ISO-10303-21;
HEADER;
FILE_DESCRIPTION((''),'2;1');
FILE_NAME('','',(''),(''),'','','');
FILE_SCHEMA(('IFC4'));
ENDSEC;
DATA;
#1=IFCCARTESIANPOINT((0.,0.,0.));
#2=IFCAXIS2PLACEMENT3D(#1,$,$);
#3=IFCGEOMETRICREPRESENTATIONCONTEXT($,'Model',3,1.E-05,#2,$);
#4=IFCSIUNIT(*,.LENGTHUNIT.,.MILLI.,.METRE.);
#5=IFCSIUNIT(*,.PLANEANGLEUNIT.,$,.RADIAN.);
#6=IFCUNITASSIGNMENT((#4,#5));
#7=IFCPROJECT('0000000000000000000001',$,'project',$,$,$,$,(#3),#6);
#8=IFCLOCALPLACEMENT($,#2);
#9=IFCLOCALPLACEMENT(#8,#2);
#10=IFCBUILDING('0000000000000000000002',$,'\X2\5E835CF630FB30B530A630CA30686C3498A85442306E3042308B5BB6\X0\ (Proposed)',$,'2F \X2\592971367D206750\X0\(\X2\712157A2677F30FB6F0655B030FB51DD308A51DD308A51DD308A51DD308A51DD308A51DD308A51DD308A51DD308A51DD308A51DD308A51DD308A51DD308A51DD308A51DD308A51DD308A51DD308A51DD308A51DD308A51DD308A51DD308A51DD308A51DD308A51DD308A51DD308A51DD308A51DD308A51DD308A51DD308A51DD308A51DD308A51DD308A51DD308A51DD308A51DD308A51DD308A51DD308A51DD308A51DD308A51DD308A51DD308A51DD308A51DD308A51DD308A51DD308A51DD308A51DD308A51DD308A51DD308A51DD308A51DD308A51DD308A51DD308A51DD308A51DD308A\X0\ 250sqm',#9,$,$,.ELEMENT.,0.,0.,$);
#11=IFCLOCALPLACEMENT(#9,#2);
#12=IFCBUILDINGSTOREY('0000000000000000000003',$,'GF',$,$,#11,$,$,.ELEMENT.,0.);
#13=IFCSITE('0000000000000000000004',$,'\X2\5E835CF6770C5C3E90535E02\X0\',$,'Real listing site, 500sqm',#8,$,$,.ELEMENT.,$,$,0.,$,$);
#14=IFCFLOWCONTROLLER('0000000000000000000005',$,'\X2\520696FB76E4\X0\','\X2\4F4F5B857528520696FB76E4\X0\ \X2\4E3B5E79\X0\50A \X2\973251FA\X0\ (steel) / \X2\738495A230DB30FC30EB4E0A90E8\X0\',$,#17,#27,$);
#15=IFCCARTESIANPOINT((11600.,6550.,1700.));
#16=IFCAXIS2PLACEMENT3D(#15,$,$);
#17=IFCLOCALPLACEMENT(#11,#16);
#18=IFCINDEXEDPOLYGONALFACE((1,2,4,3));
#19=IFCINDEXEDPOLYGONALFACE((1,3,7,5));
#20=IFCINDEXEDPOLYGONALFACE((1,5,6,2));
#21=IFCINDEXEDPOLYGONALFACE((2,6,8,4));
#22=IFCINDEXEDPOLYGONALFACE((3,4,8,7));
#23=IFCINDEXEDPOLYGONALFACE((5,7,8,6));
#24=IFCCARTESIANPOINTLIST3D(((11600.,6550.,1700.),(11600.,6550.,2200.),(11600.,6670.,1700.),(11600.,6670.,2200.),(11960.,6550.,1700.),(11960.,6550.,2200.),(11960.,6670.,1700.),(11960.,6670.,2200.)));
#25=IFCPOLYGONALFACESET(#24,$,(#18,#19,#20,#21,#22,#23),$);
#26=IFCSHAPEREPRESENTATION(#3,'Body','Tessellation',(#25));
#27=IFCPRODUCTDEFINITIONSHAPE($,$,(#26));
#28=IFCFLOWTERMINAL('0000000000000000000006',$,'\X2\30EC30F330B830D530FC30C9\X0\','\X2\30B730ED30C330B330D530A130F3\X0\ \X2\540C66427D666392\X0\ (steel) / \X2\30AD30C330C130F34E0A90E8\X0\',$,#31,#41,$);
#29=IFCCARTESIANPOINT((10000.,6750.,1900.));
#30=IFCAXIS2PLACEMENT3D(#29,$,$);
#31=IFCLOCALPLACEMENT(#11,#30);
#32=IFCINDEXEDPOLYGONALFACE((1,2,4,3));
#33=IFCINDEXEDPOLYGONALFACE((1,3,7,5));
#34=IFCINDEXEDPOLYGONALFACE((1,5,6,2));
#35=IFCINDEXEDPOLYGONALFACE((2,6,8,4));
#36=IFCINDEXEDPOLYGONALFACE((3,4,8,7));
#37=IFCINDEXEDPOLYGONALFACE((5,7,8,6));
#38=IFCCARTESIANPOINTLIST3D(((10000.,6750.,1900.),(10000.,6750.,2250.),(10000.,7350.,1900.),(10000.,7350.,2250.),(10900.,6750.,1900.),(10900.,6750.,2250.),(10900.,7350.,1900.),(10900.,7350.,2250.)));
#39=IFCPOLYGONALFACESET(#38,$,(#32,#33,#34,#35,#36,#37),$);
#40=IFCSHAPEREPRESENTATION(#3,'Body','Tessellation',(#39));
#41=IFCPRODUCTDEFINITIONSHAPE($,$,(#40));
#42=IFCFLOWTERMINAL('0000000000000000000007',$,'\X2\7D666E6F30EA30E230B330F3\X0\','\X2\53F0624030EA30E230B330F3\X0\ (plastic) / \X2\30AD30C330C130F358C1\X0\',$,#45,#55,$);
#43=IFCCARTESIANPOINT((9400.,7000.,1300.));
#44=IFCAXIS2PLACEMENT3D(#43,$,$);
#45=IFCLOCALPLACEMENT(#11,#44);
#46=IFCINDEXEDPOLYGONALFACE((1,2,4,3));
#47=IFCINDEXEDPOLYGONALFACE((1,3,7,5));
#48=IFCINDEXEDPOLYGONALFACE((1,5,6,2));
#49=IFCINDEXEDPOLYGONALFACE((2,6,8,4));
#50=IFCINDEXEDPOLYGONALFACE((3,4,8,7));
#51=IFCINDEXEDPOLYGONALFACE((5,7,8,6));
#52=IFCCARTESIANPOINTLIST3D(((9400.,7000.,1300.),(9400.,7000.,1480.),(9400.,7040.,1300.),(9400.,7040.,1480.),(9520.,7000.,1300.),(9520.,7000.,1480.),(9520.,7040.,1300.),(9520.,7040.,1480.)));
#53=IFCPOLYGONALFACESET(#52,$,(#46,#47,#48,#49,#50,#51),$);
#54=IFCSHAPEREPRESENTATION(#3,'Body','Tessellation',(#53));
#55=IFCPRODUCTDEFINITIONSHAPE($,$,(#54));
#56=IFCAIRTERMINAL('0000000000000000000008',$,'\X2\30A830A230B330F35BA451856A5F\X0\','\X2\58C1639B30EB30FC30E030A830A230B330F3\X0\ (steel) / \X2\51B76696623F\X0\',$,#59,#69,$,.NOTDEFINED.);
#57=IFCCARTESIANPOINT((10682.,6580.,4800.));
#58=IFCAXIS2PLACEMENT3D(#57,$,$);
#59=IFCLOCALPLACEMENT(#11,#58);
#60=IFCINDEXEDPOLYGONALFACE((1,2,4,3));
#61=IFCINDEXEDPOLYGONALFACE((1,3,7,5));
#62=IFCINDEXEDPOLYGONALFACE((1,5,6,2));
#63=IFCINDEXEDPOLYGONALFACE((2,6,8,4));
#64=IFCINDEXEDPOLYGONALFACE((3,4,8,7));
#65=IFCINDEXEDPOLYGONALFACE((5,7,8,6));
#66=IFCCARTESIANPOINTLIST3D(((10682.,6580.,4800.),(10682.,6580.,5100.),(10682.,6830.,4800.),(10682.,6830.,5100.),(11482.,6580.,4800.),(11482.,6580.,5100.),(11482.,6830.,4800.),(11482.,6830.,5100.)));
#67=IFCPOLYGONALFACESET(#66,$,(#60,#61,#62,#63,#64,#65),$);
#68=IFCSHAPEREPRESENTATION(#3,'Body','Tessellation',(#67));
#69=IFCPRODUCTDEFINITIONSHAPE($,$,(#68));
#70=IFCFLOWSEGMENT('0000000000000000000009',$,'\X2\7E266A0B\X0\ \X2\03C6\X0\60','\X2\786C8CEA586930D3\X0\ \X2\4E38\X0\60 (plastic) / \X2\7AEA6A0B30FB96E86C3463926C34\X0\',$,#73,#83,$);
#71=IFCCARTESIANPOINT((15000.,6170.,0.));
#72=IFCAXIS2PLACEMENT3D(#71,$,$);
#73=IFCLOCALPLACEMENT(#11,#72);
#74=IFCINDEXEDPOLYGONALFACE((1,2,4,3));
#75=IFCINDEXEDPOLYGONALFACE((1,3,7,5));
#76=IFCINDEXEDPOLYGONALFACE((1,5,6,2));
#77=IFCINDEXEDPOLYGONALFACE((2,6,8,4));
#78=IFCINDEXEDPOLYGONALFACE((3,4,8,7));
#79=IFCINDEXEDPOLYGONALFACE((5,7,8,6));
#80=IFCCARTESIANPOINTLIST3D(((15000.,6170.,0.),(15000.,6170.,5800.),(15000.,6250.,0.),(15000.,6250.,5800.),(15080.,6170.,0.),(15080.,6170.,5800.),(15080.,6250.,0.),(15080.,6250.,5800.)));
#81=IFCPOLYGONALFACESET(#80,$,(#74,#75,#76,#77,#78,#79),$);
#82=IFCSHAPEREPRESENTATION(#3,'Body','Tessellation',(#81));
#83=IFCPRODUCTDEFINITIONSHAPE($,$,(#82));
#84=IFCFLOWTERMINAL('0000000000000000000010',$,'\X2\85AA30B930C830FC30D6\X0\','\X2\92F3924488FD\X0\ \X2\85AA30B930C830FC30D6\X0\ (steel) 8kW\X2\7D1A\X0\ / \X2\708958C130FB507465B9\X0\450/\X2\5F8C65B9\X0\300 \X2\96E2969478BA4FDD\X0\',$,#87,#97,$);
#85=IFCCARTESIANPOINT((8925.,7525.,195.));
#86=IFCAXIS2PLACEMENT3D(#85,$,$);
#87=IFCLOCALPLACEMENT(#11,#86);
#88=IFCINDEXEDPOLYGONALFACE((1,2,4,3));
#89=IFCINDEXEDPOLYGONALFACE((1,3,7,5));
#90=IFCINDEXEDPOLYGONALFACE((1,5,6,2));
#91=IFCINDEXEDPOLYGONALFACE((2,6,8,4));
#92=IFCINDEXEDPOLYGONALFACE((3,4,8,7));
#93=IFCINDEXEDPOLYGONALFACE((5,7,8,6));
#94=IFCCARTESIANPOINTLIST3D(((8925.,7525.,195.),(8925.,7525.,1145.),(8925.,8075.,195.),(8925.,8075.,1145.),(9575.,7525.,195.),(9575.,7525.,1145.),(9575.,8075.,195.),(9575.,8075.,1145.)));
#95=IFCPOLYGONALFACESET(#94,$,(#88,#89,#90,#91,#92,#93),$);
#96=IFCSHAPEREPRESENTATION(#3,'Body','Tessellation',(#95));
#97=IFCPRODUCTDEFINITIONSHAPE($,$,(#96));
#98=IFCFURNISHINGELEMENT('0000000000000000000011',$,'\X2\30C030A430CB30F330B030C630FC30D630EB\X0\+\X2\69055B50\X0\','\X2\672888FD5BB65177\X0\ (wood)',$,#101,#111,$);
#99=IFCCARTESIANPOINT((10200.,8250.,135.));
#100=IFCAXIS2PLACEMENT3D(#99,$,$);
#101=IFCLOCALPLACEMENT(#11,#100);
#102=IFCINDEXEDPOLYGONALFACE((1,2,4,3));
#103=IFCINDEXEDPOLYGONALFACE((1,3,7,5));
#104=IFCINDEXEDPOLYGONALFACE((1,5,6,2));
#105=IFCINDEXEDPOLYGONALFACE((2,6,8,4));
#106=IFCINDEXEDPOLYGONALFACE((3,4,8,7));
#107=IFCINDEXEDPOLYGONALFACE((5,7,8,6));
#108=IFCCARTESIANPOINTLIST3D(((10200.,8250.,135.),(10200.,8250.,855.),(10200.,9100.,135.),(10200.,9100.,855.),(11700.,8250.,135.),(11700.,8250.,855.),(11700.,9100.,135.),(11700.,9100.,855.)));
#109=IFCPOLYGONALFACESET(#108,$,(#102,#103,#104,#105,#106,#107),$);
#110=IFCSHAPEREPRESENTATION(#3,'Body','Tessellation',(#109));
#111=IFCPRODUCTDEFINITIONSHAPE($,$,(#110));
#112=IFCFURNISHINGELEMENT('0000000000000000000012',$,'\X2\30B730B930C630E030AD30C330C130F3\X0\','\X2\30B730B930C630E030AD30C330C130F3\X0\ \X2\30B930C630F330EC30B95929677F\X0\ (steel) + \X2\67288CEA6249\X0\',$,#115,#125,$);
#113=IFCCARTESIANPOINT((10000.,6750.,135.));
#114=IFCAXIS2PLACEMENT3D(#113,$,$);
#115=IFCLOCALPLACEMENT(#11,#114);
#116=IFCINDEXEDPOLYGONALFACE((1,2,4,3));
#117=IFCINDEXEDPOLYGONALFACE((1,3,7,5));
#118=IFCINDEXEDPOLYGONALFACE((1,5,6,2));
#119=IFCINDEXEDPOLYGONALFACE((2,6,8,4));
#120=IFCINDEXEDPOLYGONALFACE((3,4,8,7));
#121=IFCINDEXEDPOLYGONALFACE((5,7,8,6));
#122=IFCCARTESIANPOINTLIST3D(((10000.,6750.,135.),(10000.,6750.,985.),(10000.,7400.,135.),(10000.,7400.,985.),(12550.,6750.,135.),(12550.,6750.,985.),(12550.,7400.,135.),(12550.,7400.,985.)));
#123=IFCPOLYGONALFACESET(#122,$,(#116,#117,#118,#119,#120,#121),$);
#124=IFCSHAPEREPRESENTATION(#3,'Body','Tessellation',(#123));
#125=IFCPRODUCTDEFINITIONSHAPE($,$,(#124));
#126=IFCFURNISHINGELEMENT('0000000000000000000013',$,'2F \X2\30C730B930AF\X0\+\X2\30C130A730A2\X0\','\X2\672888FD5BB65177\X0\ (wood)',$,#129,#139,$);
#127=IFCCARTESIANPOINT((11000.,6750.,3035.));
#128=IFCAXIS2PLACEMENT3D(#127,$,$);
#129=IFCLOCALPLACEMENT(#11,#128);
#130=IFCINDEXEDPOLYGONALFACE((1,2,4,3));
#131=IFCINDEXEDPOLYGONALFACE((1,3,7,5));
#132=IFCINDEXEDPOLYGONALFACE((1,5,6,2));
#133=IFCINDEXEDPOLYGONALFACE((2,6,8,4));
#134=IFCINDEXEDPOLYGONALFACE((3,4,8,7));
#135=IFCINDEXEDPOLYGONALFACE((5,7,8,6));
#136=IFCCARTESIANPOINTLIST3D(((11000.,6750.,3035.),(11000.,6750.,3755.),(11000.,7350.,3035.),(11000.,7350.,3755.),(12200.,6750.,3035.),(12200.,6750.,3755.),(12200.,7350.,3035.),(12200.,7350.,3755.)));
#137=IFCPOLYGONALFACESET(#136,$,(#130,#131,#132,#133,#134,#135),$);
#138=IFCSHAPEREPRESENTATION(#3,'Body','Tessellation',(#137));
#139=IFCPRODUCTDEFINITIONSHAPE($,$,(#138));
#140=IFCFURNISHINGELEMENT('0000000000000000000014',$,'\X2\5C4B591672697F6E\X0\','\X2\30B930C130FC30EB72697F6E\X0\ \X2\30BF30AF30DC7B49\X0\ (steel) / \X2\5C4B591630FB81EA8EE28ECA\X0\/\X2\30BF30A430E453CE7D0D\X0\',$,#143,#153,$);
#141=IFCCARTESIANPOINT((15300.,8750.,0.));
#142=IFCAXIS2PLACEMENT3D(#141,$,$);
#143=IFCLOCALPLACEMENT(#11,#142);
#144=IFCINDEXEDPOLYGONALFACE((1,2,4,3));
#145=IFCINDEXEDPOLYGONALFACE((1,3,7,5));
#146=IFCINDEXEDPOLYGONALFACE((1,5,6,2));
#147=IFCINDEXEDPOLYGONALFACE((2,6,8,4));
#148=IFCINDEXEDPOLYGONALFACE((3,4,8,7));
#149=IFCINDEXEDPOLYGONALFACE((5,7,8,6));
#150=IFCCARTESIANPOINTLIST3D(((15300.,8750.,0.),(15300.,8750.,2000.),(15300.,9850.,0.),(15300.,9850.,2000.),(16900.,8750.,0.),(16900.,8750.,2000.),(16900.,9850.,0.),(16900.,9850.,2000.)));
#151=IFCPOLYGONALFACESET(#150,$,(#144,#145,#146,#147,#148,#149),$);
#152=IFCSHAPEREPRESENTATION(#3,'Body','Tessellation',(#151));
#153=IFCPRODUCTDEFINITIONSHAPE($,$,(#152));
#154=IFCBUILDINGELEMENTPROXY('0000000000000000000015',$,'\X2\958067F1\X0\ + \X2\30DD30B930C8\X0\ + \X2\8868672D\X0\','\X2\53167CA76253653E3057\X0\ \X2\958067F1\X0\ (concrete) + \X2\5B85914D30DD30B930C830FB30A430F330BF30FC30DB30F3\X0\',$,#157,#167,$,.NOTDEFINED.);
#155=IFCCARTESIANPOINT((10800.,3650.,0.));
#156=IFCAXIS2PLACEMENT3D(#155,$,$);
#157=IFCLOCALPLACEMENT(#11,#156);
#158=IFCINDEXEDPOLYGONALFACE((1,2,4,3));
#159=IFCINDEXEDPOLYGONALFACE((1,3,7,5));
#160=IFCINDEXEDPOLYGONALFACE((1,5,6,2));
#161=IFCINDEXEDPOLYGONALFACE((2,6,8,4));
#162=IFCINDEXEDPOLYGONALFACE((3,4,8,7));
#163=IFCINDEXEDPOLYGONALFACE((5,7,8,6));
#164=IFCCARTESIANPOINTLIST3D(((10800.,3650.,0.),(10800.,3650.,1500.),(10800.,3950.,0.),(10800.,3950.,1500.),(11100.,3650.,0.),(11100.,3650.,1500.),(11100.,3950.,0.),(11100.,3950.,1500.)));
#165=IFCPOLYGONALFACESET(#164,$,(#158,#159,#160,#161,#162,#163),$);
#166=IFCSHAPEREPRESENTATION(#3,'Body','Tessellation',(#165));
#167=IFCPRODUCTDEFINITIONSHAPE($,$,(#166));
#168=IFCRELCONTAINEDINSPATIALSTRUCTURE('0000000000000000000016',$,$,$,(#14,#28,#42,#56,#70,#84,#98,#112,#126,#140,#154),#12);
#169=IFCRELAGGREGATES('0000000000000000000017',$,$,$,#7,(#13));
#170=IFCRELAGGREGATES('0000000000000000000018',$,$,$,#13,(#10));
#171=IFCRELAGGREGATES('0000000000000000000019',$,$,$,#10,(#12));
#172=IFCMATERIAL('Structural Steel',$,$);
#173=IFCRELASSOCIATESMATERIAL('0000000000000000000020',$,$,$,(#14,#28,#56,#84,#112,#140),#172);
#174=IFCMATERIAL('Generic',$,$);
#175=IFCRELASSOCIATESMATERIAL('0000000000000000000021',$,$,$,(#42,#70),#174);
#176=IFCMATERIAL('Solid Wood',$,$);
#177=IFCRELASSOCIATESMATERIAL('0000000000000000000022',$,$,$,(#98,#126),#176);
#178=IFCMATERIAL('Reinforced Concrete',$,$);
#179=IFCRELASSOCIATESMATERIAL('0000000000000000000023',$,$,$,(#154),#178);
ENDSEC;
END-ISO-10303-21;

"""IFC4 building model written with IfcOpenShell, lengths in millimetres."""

from ifc_helpers import new_model, si_unit, frame, frame_2d, origin, place, context, project, spatial, rectangle, extrude, material, element, save


model = new_model("IFC4")

# Units and contexts
model_context = context("Model", 3, precision=1e-05, world=origin())
ifc_project = project(units=[si_unit("LENGTHUNIT", "METRE", prefix="MILLI"), si_unit("PLANEANGLEUNIT", "RADIAN")], contexts=[model_context])

# Site, building, storey
site_placement = place(None, origin())
site = spatial("IfcSite", under=ifc_project, at=site_placement, Name="広島県尾道市", ObjectType="Real listing site, 500sqm", CompositionType="ELEMENT", RefElevation=0.0)
building_placement = place(site_placement, origin())
building = spatial("IfcBuilding", under=site, at=building_placement, Name="広島・サウナと水風呂のある家 (Proposed)", ObjectType="2F 天然素材(無垢板・漆喰・凝り凝り凝り凝り凝り凝り凝り凝り凝り凝り凝り凝り凝り凝り凝り凝り凝り凝り凝り凝り凝り凝り凝り凝り凝り凝り凝り凝り凝り凝り凝り凝り凝り凝り凝り凝り凝り凝り凝り凝り凝り凝り凝り凝り凝り凝り凝り凝り凝り凝り凝り凝り凝り凝り 250sqm", CompositionType="ELEMENT", ElevationOfRefHeight=0.0, ElevationOfTerrain=0.0)
storey_placement = place(building_placement, origin())
storey = spatial("IfcBuildingStorey", under=building, at=storey_placement, Name="GF", CompositionType="ELEMENT", Elevation=0.0)

# Shared definitions
ifc_material_1 = material(Name="Solid Wood")

# Shared definitions
ifc_material_2 = material(Name="Structural Steel")

# Shared definitions
ifc_material_3 = material(Name="Reinforced Concrete")

# Flow controller
flow_controller_placement = place(storey_placement, frame((11600.0, 6550.0, 1700.0)))
element("IfcFlowController", 1, at=flow_controller_placement, inside=storey, material=ifc_material_2, Name="分電盤", Description="住宅用分電盤 主幹50A 露出 (steel) / 玄関ホール上部", context=model_context, shape_type="SweptSolid", body=[
    extrude(rectangle(XDim=360.0, YDim=120.0, at=frame_2d((180.0, 60.0))), frame((11600.0, 6550.0, 1700.0)), (0.0, 0.0, 1.0), 500.0),
])

# Flow terminals
flow_terminal_1_placement = place(storey_placement, frame((10000.0, 6750.0, 1900.0)))
element("IfcFlowTerminal", 2, at=flow_terminal_1_placement, inside=storey, material=ifc_material_2, Name="レンジフード", Description="シロッコファン 同時給排 (steel) / キッチン上部", context=model_context, shape_type="SweptSolid", body=[
    extrude(rectangle(XDim=900.0, YDim=600.0, at=frame_2d((450.0, 300.0))), frame((10000.0, 6750.0, 1900.0)), (0.0, 0.0, 1.0), 350.0),
])
ifc_material_4 = material(Name="Generic")
flow_terminal_2_placement = place(storey_placement, frame((9400.0, 7000.0, 1300.0)))
element("IfcFlowTerminal", 3, at=flow_terminal_2_placement, inside=storey, material=ifc_material_4, Name="給湯リモコン", Description="台所リモコン (plastic) / キッチン壁", context=model_context, shape_type="SweptSolid", body=[
    extrude(rectangle(XDim=120.0, YDim=40.0, at=frame_2d((60.0, 20.0))), frame((9400.0, 7000.0, 1300.0)), (0.0, 0.0, 1.0), 180.0),
])

# Air terminal
air_terminal_placement = place(storey_placement, frame((10682.0, 6580.0, 4800.0)))
element("IfcAirTerminal", 4, at=air_terminal_placement, inside=storey, material=ifc_material_2, Name="エアコン室内機", Description="壁掛ルームエアコン (steel) / 冷暖房", PredefinedType="NOTDEFINED", context=model_context, shape_type="SweptSolid", body=[
    extrude(rectangle(XDim=800.0, YDim=250.0, at=frame_2d((400.0, 125.0))), frame((10682.0, 6580.0, 4800.0)), (0.0, 0.0, 1.0), 300.0),
])

# Flow segment
flow_segment_placement = place(storey_placement, frame((15000.0, 6170.0, 0.0)))
element("IfcFlowSegment", 5, at=flow_segment_placement, inside=storey, material=ifc_material_4, Name="縦樋 φ60", Description="硬質塩ビ 丸60 (plastic) / 竪樋・雨水排水", context=model_context, shape_type="SweptSolid", body=[
    extrude(rectangle(XDim=80.0, YDim=80.0, at=frame_2d((40.0, 40.0))), frame((15000.0, 6170.0, 0.0)), (0.0, 0.0, 1.0), 5800.0),
])

# Flow terminal
flow_terminal_3_placement = place(storey_placement, frame((8925.0, 7525.0, 195.0)))
element("IfcFlowTerminal", 6, at=flow_terminal_3_placement, inside=storey, material=ifc_material_2, Name="薪ストーブ", Description="鋳鉄製 薪ストーブ (steel) 8kW級 / 炉壁・側方450/後方300 離隔確保", context=model_context, shape_type="SweptSolid", body=[
    extrude(rectangle(XDim=650.0, YDim=550.0, at=frame_2d((325.0, 275.0))), frame((8925.0, 7525.0, 195.0)), (0.0, 0.0, 1.0), 950.0),
])

# Furnishing elements
furnishing_1_placement = place(storey_placement, frame((10200.0, 8250.0, 135.0)))
element("IfcFurnishingElement", 7, at=furnishing_1_placement, inside=storey, material=ifc_material_1, Name="ダイニングテーブル+椅子", Description="木製家具 (wood)", context=model_context, shape_type="SweptSolid", body=[
    extrude(rectangle(XDim=1500.0, YDim=850.0, at=frame_2d((750.0, 425.0))), frame((10200.0, 8250.0, 135.0)), (0.0, 0.0, 1.0), 720.0),
])
furnishing_2_placement = place(storey_placement, frame((10000.0, 6750.0, 135.0)))
element("IfcFurnishingElement", 8, at=furnishing_2_placement, inside=storey, material=ifc_material_2, Name="システムキッチン", Description="システムキッチン ステンレス天板 (steel) + 木質扉", context=model_context, shape_type="SweptSolid", body=[
    extrude(rectangle(XDim=2550.0, YDim=650.0, at=frame_2d((1275.0, 325.0))), frame((10000.0, 6750.0, 135.0)), (0.0, 0.0, 1.0), 850.0),
])
furnishing_3_placement = place(storey_placement, frame((11000.0, 6750.0, 3035.0)))
element("IfcFurnishingElement", 9, at=furnishing_3_placement, inside=storey, material=ifc_material_1, Name="2F デスク+チェア", Description="木製家具 (wood)", context=model_context, shape_type="SweptSolid", body=[
    extrude(rectangle(XDim=1200.0, YDim=600.0, at=frame_2d((600.0, 300.0))), frame((11000.0, 6750.0, 3035.0)), (0.0, 0.0, 1.0), 720.0),
])
furnishing_4_placement = place(storey_placement, frame((15300.0, 8750.0, 0.0)))
element("IfcFurnishingElement", 10, at=furnishing_4_placement, inside=storey, material=ifc_material_2, Name="屋外物置", Description="スチール物置 タクボ等 (steel) / 屋外・自転車/タイヤ収納", context=model_context, shape_type="SweptSolid", body=[
    extrude(rectangle(XDim=1600.0, YDim=1100.0, at=frame_2d((800.0, 550.0))), frame((15300.0, 8750.0, 0.0)), (0.0, 0.0, 1.0), 2000.0),
])

# Building element proxy
proxy_placement = place(storey_placement, frame((10800.0, 3650.0, 0.0)))
element("IfcBuildingElementProxy", 11, at=proxy_placement, inside=storey, material=ifc_material_3, Name="門柱 + ポスト + 表札", Description="化粧打放し 門柱 (concrete) + 宅配ポスト・インターホン", PredefinedType="NOTDEFINED", context=model_context, shape_type="SweptSolid", body=[
    extrude(rectangle(XDim=300.0, YDim=300.0, at=frame_2d((150.0, 150.0))), frame((10800.0, 3650.0, 0.0)), (0.0, 0.0, 1.0), 1500.0),
])

save(model, "model.ifc")
